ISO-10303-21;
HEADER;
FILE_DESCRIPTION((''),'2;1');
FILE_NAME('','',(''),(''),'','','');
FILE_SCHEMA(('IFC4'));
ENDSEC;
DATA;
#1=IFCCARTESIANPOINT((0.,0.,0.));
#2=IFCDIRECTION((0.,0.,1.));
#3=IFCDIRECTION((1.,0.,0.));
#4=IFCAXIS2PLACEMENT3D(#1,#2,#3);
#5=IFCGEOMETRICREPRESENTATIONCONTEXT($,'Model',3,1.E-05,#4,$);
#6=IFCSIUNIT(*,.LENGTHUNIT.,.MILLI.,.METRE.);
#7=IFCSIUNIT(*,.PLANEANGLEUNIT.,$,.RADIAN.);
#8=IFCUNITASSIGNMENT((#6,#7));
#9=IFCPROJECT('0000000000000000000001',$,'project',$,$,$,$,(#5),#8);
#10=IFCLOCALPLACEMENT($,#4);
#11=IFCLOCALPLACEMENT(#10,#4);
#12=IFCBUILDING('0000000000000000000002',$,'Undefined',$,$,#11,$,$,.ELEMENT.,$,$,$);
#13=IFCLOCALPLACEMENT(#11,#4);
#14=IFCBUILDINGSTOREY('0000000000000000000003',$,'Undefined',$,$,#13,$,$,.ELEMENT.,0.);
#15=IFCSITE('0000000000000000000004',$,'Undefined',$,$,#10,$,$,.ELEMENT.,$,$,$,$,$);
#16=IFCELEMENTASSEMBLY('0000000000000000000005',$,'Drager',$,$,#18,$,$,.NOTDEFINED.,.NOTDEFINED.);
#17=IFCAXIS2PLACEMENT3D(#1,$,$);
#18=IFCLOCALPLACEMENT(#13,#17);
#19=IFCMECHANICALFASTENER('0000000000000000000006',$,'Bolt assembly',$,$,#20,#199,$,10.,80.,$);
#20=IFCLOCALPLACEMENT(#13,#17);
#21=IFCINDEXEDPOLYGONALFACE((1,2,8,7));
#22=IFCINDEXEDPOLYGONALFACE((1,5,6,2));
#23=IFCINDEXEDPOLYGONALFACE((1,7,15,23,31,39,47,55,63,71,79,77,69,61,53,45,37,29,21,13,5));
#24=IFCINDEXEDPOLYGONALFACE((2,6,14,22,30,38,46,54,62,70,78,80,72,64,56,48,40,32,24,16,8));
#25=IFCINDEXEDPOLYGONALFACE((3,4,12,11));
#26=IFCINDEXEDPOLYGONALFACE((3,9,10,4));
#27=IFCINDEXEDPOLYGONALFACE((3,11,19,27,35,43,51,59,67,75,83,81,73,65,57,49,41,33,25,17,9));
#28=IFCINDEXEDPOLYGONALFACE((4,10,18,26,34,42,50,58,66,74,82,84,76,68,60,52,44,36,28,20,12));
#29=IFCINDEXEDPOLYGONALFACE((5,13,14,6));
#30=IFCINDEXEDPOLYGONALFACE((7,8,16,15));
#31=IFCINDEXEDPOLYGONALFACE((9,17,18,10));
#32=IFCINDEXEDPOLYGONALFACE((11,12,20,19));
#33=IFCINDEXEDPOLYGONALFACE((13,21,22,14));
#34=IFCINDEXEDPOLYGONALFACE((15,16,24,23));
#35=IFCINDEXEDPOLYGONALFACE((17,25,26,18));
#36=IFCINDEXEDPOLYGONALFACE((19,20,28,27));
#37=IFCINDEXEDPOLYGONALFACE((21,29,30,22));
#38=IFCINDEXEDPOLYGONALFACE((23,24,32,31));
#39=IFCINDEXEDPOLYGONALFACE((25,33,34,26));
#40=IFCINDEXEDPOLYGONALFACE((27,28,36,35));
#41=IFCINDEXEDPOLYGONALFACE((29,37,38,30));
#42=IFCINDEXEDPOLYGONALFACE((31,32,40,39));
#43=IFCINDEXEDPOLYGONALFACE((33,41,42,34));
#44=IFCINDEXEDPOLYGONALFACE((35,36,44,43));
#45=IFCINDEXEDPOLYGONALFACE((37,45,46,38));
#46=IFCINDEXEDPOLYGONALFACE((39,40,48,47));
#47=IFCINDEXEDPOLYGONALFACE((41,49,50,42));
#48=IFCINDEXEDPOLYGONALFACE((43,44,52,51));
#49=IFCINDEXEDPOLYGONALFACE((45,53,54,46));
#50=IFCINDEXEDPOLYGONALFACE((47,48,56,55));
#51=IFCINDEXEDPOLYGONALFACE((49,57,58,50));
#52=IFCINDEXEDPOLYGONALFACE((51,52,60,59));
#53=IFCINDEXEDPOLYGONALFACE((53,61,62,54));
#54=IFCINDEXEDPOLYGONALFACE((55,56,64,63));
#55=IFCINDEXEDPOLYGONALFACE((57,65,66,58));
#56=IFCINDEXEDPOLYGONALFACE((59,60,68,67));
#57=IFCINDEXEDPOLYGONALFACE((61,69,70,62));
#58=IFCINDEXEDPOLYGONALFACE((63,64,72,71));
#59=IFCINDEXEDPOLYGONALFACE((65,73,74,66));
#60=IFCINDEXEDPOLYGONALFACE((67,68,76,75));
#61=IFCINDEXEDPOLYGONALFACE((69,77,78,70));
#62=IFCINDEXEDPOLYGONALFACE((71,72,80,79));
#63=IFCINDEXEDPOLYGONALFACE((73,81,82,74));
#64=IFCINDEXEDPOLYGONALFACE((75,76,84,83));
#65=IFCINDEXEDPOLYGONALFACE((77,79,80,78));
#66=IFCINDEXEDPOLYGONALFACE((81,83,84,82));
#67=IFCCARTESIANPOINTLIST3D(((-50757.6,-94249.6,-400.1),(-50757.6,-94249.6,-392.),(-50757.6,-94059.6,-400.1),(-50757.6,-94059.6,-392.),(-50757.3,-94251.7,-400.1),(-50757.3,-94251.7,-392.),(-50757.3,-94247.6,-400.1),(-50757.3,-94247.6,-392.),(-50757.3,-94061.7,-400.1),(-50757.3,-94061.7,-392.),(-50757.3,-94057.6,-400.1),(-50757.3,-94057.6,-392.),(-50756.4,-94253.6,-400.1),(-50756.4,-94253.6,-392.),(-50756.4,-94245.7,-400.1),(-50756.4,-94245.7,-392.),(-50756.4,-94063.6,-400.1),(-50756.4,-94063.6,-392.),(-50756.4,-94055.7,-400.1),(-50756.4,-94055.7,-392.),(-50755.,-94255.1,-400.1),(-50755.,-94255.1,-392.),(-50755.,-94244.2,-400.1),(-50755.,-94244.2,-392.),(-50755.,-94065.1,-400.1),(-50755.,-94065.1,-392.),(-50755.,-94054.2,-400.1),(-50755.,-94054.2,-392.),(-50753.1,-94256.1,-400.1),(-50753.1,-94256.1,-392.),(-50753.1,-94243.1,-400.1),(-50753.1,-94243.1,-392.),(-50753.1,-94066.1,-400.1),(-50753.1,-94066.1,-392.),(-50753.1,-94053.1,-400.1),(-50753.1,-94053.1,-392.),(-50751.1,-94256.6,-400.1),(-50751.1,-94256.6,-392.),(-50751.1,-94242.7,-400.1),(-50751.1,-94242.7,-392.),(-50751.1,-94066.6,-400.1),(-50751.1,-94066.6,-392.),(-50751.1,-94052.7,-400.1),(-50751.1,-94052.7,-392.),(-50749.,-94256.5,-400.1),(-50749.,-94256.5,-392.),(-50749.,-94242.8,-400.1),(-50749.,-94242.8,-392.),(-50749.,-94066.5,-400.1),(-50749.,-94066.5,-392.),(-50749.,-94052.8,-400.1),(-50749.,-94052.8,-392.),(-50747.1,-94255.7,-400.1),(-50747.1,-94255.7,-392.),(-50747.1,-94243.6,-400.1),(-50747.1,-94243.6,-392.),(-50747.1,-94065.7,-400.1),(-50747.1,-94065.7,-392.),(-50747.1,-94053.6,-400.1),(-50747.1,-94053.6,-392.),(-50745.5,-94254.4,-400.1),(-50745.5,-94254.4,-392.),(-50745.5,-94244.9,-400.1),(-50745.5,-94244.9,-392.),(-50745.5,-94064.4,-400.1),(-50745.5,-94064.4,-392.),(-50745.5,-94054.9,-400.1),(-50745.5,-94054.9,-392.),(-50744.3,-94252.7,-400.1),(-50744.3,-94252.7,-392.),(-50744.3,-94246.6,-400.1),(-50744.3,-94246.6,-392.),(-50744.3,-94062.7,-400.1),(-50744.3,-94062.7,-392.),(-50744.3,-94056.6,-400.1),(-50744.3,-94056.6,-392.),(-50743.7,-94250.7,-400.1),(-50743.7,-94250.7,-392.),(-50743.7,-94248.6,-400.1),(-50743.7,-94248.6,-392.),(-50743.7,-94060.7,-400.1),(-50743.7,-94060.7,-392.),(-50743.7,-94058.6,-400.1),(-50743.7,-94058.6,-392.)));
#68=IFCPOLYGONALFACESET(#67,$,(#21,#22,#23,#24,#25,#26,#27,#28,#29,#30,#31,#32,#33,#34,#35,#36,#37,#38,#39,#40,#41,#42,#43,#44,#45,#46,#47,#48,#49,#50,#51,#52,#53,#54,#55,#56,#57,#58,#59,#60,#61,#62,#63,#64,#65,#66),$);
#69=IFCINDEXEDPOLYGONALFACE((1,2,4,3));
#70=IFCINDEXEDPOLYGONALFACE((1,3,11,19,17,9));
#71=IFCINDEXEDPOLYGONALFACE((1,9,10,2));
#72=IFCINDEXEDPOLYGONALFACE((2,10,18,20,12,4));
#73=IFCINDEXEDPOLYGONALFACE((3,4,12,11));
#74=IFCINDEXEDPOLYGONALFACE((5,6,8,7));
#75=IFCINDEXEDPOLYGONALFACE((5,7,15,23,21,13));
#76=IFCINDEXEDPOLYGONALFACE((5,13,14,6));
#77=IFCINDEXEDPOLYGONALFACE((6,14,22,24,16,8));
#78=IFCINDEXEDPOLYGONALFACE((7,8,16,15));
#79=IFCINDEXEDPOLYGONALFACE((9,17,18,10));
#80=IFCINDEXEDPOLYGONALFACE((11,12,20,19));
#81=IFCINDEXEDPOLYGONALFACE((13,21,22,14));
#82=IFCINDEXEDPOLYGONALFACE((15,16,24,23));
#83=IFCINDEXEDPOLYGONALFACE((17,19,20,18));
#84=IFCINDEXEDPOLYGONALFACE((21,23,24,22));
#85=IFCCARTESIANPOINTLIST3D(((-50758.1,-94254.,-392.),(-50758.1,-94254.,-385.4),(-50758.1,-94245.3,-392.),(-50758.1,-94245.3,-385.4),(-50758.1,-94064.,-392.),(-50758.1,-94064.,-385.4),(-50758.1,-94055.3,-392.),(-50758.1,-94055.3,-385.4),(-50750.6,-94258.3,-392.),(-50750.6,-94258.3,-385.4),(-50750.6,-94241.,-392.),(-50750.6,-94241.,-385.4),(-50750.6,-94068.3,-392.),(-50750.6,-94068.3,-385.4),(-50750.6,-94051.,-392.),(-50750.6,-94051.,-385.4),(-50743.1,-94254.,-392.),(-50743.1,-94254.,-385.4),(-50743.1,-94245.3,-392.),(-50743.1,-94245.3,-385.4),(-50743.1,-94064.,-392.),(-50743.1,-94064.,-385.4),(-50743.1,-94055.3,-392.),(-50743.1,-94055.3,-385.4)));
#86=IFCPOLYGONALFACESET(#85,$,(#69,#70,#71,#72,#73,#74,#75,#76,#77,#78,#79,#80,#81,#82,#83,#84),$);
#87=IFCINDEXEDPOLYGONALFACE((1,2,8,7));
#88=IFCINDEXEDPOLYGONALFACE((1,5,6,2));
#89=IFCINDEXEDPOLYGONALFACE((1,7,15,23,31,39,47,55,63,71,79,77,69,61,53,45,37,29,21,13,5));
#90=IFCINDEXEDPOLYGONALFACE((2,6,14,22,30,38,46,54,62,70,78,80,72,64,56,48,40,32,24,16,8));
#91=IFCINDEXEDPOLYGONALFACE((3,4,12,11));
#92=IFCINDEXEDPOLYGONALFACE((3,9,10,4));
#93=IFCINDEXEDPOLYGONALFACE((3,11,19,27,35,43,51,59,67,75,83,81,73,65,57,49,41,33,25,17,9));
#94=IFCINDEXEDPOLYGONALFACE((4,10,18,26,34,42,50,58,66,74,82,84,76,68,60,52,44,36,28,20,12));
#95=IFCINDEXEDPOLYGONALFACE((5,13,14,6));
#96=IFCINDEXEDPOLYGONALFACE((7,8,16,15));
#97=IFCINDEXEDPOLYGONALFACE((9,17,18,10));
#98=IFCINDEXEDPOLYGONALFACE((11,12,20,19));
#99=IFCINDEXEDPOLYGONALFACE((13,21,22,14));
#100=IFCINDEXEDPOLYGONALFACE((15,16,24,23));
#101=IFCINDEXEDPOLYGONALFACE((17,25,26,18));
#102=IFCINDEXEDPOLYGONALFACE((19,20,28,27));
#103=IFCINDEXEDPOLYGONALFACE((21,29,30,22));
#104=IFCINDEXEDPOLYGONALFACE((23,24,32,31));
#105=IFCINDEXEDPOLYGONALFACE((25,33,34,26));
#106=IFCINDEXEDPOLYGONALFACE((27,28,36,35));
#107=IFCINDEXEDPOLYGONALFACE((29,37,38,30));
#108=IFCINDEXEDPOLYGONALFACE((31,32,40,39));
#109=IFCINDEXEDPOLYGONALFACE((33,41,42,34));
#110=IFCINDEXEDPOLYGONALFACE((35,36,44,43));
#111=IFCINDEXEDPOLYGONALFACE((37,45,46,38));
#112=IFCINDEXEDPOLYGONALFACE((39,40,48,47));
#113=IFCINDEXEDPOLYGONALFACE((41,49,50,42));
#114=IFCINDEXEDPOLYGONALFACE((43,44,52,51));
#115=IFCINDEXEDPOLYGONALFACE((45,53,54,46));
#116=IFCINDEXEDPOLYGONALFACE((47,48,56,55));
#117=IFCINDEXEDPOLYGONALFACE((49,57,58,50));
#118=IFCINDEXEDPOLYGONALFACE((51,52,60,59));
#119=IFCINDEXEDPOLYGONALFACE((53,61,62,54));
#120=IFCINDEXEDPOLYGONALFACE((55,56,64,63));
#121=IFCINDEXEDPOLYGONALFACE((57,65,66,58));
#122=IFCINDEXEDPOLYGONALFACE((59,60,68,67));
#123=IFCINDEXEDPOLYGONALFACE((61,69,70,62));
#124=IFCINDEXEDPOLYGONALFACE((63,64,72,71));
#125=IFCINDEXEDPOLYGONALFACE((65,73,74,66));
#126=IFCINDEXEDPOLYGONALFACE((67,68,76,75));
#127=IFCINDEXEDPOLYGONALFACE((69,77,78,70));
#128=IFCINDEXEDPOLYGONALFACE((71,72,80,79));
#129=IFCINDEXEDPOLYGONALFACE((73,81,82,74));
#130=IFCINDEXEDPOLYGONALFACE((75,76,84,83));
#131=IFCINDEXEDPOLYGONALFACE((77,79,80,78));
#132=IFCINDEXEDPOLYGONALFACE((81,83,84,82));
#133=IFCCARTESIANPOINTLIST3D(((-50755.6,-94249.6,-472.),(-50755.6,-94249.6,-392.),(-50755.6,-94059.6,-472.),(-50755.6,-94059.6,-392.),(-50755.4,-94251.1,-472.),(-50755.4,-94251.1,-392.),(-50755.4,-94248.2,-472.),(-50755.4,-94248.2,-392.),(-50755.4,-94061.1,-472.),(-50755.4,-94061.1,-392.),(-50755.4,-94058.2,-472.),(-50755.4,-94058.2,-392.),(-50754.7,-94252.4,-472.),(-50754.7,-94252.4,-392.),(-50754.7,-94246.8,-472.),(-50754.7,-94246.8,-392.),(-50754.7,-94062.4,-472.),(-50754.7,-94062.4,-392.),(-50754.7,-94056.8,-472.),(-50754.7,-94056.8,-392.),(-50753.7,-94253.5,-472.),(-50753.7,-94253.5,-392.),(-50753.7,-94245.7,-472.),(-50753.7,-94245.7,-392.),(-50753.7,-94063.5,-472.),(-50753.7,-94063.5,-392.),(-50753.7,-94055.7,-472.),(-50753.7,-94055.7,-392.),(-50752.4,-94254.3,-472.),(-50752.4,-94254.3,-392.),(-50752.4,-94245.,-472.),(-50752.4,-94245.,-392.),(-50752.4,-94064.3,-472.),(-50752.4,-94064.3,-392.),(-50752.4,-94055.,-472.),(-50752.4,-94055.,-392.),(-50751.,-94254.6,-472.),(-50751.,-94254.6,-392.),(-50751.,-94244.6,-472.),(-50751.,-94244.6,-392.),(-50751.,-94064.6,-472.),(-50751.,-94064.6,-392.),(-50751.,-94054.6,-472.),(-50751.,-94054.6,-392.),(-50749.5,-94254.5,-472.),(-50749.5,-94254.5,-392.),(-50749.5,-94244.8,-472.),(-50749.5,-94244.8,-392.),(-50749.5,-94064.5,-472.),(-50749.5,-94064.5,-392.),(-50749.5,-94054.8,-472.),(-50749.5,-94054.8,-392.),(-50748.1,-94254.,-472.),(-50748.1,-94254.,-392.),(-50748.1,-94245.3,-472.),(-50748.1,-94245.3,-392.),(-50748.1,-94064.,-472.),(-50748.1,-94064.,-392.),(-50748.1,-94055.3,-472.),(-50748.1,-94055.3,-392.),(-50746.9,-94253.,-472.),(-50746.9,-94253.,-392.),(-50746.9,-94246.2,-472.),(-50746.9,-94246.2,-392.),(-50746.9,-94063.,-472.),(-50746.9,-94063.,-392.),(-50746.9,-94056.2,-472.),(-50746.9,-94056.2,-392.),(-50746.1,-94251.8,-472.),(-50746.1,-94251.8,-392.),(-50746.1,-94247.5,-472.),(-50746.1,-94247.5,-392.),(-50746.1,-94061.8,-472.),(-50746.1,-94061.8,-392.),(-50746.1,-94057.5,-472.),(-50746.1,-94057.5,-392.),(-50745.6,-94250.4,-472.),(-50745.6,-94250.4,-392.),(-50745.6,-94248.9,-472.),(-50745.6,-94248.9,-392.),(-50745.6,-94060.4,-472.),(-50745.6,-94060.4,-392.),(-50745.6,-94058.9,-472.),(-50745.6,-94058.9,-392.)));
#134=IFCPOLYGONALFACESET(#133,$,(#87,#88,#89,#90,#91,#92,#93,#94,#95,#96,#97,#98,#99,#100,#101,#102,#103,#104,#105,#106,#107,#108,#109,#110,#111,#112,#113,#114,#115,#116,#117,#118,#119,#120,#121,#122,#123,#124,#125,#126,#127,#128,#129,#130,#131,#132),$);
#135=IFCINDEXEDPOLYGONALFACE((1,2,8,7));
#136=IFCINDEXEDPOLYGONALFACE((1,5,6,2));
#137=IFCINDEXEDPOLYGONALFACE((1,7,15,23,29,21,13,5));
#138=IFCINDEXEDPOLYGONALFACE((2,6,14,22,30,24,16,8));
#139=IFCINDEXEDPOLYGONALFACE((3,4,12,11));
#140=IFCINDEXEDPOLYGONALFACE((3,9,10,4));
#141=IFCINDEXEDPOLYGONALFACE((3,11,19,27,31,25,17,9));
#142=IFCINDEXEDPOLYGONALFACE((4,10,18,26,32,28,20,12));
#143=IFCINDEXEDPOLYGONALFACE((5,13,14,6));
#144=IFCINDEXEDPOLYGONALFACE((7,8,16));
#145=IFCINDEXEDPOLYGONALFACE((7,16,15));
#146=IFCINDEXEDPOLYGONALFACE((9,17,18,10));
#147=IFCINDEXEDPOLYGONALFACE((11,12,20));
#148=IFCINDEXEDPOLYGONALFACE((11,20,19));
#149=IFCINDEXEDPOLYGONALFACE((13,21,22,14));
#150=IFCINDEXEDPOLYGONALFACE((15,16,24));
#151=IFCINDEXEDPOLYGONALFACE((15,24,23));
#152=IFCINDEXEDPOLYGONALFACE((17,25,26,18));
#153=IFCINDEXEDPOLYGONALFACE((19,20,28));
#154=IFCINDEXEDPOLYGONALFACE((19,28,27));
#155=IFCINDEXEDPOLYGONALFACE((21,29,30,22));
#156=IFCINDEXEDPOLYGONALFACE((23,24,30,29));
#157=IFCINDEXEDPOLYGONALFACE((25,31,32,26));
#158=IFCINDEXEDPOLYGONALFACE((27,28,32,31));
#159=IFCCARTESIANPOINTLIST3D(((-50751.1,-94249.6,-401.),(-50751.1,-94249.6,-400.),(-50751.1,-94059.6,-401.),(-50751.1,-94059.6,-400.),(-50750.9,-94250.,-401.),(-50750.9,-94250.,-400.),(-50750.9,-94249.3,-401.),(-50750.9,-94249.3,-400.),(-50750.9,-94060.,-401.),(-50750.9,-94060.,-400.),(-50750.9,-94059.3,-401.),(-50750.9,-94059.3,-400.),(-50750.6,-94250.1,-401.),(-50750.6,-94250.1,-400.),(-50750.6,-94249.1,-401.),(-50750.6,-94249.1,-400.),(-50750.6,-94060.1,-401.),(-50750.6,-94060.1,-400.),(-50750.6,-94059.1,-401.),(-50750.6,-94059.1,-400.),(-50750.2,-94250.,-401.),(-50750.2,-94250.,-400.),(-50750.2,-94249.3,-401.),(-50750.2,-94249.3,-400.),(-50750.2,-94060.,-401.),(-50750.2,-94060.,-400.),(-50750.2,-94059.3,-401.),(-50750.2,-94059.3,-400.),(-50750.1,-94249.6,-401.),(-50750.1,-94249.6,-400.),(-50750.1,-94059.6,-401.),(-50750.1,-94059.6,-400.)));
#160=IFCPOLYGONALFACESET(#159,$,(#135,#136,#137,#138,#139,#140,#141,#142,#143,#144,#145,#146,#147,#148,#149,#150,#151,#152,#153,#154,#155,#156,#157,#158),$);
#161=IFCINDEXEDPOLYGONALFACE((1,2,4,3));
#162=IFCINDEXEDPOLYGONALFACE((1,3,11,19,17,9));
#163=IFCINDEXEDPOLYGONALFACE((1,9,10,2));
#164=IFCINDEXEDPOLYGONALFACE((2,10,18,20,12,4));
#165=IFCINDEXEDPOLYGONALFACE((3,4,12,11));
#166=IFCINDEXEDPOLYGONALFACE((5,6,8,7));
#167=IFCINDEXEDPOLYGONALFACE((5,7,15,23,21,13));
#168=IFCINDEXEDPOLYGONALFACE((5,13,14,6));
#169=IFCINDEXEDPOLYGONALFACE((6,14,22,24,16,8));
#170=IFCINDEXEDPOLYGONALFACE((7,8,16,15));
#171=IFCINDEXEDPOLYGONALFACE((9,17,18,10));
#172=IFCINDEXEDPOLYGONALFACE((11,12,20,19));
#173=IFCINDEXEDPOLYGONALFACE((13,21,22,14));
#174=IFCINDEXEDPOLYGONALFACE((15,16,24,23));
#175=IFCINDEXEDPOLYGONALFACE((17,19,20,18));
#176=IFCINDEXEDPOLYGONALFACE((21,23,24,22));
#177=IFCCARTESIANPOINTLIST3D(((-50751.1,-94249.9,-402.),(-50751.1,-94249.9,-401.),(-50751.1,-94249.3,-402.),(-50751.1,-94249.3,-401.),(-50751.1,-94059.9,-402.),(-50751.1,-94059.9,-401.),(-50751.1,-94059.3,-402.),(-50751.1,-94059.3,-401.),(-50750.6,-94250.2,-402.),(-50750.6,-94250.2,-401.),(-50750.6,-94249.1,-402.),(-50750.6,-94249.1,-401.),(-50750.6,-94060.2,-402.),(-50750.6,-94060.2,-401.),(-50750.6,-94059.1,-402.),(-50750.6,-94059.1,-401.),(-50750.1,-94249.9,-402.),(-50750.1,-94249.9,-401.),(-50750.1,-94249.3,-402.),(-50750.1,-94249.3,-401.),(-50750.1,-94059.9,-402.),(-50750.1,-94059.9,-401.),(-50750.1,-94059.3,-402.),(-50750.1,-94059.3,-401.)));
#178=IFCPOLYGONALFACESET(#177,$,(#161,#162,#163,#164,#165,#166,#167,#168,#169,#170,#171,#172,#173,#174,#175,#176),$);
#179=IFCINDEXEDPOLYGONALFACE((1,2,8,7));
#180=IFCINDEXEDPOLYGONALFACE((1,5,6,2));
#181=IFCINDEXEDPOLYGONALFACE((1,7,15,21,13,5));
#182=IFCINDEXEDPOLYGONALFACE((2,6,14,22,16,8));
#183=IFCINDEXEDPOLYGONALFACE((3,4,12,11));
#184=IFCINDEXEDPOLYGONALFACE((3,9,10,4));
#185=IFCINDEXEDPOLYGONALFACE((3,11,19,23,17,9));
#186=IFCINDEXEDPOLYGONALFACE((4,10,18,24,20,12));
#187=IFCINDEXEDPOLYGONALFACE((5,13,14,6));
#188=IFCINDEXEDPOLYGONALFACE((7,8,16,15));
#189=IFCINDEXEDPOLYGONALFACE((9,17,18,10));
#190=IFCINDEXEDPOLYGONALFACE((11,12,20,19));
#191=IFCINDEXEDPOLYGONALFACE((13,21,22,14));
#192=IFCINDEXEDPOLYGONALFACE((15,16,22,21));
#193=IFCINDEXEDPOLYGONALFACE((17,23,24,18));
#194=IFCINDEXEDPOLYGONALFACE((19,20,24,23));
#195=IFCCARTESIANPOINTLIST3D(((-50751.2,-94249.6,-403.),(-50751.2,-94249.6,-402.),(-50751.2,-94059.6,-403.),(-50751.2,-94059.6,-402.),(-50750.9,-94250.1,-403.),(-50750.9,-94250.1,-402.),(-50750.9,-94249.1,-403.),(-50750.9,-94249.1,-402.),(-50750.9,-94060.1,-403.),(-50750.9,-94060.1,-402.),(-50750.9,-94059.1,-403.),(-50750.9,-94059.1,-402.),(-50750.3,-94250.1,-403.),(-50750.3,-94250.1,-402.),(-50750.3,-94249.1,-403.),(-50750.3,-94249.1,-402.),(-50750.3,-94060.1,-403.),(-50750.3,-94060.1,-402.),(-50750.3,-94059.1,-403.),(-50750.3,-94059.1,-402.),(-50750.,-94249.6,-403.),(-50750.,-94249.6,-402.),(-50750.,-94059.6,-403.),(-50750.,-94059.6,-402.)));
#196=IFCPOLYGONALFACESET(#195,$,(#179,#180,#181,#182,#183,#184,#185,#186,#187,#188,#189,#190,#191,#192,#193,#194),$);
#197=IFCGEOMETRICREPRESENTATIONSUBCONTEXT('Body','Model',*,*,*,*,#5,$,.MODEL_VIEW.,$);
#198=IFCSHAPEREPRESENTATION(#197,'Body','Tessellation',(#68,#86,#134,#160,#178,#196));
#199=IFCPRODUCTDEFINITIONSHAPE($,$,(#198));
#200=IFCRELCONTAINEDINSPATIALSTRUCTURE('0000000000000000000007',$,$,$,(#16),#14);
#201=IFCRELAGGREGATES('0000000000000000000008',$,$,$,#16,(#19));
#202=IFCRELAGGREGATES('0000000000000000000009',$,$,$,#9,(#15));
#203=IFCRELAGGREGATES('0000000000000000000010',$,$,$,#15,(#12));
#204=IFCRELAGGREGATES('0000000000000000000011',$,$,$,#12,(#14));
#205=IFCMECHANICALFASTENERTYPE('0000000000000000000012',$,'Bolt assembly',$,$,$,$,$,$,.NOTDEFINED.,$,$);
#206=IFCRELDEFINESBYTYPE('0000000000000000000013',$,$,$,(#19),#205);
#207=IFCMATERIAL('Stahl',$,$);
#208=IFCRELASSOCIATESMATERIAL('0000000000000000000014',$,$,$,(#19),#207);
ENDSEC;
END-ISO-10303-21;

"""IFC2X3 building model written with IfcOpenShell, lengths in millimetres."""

from ifc_helpers import new_model, si_unit, frame, origin_with_axes, origin_2d_with_axis, place, context, subcontext, project, spatial, polyline, circle, outline, extrude, source, transform, mapped, material, type_object, element, aggregate, save


model = new_model("IFC2X3")

# Units and contexts
model_context = context("Model", 3, precision=1e-05, world=origin_with_axes())
body_context = subcontext(model_context, "Body", "Model", "MODEL_VIEW")
ifc_project = project(units=[si_unit("LENGTHUNIT", "METRE", prefix="MILLI"), si_unit("PLANEANGLEUNIT", "RADIAN")], contexts=[model_context])

# Site, building, storey
site_placement = place(None, origin_with_axes())
site = spatial("IfcSite", under=ifc_project, at=site_placement, Name="Undefined", CompositionType="ELEMENT")
building_placement = place(site_placement, origin_with_axes())
building = spatial("IfcBuilding", under=site, at=building_placement, Name="Undefined", CompositionType="ELEMENT")
storey_placement = place(building_placement, origin_with_axes())
storey = spatial("IfcBuildingStorey", under=building, at=storey_placement, Name="Undefined", CompositionType="ELEMENT", Elevation=0.0)

# Element assembly
assembly_1_placement = place(storey_placement, origin_with_axes())
assembly_1 = element("IfcElementAssembly", 1, at=assembly_1_placement, inside=storey, Name="Drager", AssemblyPlace="NOTDEFINED", PredefinedType="NOTDEFINED")

# Mechanical fastener
mechanical_fastener_type = type_object("IfcMechanicalFastenerType", Name="Bolt assembly")
ifc_material_1 = material(Name="Stahl")
shared_shape_1 = source(origin_with_axes(), body_context, "Body", "SweptSolid", [
    extrude(circle(Radius=7.0, at=origin_2d_with_axis()), frame((0.0, 0.0, 0.0), z_axis=(0.0, 1.0, 0.0), x_axis=(1.0, 0.0, 0.0)), (0.0, 0.0, 1.0), 8.1),
    extrude(outline(polyline([(7.5, -4.3), (7.5, 4.3), (0.0, 8.7), (-7.5, 4.3), (-7.5, -4.3), (0.0, -8.7), (7.5, -4.3)])), frame((0.0, -6.6, 0.0), z_axis=(0.0, 1.0, 0.0), x_axis=(1.0, 0.0, 0.0)), (0.0, 0.0, 1.0), 6.6),
    extrude(circle(Radius=5.0, at=origin_2d_with_axis()), frame((0.0, 0.0, 0.0), z_axis=(0.0, 1.0, 0.0), x_axis=(1.0, 0.0, 0.0)), (0.0, 0.0, 1.0), 80.0),
    extrude(circle(Radius=0.5, at=origin_2d_with_axis()), frame((0.0, 8.0, 0.0), z_axis=(0.0, 1.0, 0.0), x_axis=(1.0, 0.0, 0.0)), (0.0, 0.0, 1.0), 1.0),
    extrude(outline(polyline([(0.5, -0.3), (0.5, 0.3), (0.0, 0.6), (-0.5, 0.3), (-0.5, -0.3), (0.0, -0.6), (0.5, -0.3)])), frame((0.0, 9.0, 0.0), z_axis=(0.0, 1.0, 0.0), x_axis=(1.0, 0.0, 0.0)), (0.0, 0.0, 1.0), 1.0),
    extrude(outline(polyline([(0.6, 0.0), (0.3, 0.5), (-0.3, 0.5), (-0.6, 0.0), (-0.3, -0.5), (0.3, -0.5), (0.6, 0.0)])), frame((0.0, 10.0, 0.0), z_axis=(0.0, 1.0, 0.0), x_axis=(1.0, 0.0, 0.0)), (0.0, 0.0, 1.0), 1.0),
])
mechanical_fastener_1_placement = place(assembly_1_placement, frame((-50750.6, -94154.6, -392.0), z_axis=(0.0, -1.0, 0.0), x_axis=(-1.0, 0.0, 0.0)))
mechanical_fastener_1 = element("IfcMechanicalFastener", 2, at=mechanical_fastener_1_placement, type_object=mechanical_fastener_type, material=ifc_material_1, Name="Bolt assembly", NominalDiameter=10.0, NominalLength=80.0, context=body_context, shape_type="MappedRepresentation", body=[
    mapped(shared_shape_1, transform((0.0, 0.0, -95.0))),
    mapped(shared_shape_1, transform((0.0, 0.0, 95.0))),
])
aggregate(assembly_1, [mechanical_fastener_1])

save(model, "model.ifc")
